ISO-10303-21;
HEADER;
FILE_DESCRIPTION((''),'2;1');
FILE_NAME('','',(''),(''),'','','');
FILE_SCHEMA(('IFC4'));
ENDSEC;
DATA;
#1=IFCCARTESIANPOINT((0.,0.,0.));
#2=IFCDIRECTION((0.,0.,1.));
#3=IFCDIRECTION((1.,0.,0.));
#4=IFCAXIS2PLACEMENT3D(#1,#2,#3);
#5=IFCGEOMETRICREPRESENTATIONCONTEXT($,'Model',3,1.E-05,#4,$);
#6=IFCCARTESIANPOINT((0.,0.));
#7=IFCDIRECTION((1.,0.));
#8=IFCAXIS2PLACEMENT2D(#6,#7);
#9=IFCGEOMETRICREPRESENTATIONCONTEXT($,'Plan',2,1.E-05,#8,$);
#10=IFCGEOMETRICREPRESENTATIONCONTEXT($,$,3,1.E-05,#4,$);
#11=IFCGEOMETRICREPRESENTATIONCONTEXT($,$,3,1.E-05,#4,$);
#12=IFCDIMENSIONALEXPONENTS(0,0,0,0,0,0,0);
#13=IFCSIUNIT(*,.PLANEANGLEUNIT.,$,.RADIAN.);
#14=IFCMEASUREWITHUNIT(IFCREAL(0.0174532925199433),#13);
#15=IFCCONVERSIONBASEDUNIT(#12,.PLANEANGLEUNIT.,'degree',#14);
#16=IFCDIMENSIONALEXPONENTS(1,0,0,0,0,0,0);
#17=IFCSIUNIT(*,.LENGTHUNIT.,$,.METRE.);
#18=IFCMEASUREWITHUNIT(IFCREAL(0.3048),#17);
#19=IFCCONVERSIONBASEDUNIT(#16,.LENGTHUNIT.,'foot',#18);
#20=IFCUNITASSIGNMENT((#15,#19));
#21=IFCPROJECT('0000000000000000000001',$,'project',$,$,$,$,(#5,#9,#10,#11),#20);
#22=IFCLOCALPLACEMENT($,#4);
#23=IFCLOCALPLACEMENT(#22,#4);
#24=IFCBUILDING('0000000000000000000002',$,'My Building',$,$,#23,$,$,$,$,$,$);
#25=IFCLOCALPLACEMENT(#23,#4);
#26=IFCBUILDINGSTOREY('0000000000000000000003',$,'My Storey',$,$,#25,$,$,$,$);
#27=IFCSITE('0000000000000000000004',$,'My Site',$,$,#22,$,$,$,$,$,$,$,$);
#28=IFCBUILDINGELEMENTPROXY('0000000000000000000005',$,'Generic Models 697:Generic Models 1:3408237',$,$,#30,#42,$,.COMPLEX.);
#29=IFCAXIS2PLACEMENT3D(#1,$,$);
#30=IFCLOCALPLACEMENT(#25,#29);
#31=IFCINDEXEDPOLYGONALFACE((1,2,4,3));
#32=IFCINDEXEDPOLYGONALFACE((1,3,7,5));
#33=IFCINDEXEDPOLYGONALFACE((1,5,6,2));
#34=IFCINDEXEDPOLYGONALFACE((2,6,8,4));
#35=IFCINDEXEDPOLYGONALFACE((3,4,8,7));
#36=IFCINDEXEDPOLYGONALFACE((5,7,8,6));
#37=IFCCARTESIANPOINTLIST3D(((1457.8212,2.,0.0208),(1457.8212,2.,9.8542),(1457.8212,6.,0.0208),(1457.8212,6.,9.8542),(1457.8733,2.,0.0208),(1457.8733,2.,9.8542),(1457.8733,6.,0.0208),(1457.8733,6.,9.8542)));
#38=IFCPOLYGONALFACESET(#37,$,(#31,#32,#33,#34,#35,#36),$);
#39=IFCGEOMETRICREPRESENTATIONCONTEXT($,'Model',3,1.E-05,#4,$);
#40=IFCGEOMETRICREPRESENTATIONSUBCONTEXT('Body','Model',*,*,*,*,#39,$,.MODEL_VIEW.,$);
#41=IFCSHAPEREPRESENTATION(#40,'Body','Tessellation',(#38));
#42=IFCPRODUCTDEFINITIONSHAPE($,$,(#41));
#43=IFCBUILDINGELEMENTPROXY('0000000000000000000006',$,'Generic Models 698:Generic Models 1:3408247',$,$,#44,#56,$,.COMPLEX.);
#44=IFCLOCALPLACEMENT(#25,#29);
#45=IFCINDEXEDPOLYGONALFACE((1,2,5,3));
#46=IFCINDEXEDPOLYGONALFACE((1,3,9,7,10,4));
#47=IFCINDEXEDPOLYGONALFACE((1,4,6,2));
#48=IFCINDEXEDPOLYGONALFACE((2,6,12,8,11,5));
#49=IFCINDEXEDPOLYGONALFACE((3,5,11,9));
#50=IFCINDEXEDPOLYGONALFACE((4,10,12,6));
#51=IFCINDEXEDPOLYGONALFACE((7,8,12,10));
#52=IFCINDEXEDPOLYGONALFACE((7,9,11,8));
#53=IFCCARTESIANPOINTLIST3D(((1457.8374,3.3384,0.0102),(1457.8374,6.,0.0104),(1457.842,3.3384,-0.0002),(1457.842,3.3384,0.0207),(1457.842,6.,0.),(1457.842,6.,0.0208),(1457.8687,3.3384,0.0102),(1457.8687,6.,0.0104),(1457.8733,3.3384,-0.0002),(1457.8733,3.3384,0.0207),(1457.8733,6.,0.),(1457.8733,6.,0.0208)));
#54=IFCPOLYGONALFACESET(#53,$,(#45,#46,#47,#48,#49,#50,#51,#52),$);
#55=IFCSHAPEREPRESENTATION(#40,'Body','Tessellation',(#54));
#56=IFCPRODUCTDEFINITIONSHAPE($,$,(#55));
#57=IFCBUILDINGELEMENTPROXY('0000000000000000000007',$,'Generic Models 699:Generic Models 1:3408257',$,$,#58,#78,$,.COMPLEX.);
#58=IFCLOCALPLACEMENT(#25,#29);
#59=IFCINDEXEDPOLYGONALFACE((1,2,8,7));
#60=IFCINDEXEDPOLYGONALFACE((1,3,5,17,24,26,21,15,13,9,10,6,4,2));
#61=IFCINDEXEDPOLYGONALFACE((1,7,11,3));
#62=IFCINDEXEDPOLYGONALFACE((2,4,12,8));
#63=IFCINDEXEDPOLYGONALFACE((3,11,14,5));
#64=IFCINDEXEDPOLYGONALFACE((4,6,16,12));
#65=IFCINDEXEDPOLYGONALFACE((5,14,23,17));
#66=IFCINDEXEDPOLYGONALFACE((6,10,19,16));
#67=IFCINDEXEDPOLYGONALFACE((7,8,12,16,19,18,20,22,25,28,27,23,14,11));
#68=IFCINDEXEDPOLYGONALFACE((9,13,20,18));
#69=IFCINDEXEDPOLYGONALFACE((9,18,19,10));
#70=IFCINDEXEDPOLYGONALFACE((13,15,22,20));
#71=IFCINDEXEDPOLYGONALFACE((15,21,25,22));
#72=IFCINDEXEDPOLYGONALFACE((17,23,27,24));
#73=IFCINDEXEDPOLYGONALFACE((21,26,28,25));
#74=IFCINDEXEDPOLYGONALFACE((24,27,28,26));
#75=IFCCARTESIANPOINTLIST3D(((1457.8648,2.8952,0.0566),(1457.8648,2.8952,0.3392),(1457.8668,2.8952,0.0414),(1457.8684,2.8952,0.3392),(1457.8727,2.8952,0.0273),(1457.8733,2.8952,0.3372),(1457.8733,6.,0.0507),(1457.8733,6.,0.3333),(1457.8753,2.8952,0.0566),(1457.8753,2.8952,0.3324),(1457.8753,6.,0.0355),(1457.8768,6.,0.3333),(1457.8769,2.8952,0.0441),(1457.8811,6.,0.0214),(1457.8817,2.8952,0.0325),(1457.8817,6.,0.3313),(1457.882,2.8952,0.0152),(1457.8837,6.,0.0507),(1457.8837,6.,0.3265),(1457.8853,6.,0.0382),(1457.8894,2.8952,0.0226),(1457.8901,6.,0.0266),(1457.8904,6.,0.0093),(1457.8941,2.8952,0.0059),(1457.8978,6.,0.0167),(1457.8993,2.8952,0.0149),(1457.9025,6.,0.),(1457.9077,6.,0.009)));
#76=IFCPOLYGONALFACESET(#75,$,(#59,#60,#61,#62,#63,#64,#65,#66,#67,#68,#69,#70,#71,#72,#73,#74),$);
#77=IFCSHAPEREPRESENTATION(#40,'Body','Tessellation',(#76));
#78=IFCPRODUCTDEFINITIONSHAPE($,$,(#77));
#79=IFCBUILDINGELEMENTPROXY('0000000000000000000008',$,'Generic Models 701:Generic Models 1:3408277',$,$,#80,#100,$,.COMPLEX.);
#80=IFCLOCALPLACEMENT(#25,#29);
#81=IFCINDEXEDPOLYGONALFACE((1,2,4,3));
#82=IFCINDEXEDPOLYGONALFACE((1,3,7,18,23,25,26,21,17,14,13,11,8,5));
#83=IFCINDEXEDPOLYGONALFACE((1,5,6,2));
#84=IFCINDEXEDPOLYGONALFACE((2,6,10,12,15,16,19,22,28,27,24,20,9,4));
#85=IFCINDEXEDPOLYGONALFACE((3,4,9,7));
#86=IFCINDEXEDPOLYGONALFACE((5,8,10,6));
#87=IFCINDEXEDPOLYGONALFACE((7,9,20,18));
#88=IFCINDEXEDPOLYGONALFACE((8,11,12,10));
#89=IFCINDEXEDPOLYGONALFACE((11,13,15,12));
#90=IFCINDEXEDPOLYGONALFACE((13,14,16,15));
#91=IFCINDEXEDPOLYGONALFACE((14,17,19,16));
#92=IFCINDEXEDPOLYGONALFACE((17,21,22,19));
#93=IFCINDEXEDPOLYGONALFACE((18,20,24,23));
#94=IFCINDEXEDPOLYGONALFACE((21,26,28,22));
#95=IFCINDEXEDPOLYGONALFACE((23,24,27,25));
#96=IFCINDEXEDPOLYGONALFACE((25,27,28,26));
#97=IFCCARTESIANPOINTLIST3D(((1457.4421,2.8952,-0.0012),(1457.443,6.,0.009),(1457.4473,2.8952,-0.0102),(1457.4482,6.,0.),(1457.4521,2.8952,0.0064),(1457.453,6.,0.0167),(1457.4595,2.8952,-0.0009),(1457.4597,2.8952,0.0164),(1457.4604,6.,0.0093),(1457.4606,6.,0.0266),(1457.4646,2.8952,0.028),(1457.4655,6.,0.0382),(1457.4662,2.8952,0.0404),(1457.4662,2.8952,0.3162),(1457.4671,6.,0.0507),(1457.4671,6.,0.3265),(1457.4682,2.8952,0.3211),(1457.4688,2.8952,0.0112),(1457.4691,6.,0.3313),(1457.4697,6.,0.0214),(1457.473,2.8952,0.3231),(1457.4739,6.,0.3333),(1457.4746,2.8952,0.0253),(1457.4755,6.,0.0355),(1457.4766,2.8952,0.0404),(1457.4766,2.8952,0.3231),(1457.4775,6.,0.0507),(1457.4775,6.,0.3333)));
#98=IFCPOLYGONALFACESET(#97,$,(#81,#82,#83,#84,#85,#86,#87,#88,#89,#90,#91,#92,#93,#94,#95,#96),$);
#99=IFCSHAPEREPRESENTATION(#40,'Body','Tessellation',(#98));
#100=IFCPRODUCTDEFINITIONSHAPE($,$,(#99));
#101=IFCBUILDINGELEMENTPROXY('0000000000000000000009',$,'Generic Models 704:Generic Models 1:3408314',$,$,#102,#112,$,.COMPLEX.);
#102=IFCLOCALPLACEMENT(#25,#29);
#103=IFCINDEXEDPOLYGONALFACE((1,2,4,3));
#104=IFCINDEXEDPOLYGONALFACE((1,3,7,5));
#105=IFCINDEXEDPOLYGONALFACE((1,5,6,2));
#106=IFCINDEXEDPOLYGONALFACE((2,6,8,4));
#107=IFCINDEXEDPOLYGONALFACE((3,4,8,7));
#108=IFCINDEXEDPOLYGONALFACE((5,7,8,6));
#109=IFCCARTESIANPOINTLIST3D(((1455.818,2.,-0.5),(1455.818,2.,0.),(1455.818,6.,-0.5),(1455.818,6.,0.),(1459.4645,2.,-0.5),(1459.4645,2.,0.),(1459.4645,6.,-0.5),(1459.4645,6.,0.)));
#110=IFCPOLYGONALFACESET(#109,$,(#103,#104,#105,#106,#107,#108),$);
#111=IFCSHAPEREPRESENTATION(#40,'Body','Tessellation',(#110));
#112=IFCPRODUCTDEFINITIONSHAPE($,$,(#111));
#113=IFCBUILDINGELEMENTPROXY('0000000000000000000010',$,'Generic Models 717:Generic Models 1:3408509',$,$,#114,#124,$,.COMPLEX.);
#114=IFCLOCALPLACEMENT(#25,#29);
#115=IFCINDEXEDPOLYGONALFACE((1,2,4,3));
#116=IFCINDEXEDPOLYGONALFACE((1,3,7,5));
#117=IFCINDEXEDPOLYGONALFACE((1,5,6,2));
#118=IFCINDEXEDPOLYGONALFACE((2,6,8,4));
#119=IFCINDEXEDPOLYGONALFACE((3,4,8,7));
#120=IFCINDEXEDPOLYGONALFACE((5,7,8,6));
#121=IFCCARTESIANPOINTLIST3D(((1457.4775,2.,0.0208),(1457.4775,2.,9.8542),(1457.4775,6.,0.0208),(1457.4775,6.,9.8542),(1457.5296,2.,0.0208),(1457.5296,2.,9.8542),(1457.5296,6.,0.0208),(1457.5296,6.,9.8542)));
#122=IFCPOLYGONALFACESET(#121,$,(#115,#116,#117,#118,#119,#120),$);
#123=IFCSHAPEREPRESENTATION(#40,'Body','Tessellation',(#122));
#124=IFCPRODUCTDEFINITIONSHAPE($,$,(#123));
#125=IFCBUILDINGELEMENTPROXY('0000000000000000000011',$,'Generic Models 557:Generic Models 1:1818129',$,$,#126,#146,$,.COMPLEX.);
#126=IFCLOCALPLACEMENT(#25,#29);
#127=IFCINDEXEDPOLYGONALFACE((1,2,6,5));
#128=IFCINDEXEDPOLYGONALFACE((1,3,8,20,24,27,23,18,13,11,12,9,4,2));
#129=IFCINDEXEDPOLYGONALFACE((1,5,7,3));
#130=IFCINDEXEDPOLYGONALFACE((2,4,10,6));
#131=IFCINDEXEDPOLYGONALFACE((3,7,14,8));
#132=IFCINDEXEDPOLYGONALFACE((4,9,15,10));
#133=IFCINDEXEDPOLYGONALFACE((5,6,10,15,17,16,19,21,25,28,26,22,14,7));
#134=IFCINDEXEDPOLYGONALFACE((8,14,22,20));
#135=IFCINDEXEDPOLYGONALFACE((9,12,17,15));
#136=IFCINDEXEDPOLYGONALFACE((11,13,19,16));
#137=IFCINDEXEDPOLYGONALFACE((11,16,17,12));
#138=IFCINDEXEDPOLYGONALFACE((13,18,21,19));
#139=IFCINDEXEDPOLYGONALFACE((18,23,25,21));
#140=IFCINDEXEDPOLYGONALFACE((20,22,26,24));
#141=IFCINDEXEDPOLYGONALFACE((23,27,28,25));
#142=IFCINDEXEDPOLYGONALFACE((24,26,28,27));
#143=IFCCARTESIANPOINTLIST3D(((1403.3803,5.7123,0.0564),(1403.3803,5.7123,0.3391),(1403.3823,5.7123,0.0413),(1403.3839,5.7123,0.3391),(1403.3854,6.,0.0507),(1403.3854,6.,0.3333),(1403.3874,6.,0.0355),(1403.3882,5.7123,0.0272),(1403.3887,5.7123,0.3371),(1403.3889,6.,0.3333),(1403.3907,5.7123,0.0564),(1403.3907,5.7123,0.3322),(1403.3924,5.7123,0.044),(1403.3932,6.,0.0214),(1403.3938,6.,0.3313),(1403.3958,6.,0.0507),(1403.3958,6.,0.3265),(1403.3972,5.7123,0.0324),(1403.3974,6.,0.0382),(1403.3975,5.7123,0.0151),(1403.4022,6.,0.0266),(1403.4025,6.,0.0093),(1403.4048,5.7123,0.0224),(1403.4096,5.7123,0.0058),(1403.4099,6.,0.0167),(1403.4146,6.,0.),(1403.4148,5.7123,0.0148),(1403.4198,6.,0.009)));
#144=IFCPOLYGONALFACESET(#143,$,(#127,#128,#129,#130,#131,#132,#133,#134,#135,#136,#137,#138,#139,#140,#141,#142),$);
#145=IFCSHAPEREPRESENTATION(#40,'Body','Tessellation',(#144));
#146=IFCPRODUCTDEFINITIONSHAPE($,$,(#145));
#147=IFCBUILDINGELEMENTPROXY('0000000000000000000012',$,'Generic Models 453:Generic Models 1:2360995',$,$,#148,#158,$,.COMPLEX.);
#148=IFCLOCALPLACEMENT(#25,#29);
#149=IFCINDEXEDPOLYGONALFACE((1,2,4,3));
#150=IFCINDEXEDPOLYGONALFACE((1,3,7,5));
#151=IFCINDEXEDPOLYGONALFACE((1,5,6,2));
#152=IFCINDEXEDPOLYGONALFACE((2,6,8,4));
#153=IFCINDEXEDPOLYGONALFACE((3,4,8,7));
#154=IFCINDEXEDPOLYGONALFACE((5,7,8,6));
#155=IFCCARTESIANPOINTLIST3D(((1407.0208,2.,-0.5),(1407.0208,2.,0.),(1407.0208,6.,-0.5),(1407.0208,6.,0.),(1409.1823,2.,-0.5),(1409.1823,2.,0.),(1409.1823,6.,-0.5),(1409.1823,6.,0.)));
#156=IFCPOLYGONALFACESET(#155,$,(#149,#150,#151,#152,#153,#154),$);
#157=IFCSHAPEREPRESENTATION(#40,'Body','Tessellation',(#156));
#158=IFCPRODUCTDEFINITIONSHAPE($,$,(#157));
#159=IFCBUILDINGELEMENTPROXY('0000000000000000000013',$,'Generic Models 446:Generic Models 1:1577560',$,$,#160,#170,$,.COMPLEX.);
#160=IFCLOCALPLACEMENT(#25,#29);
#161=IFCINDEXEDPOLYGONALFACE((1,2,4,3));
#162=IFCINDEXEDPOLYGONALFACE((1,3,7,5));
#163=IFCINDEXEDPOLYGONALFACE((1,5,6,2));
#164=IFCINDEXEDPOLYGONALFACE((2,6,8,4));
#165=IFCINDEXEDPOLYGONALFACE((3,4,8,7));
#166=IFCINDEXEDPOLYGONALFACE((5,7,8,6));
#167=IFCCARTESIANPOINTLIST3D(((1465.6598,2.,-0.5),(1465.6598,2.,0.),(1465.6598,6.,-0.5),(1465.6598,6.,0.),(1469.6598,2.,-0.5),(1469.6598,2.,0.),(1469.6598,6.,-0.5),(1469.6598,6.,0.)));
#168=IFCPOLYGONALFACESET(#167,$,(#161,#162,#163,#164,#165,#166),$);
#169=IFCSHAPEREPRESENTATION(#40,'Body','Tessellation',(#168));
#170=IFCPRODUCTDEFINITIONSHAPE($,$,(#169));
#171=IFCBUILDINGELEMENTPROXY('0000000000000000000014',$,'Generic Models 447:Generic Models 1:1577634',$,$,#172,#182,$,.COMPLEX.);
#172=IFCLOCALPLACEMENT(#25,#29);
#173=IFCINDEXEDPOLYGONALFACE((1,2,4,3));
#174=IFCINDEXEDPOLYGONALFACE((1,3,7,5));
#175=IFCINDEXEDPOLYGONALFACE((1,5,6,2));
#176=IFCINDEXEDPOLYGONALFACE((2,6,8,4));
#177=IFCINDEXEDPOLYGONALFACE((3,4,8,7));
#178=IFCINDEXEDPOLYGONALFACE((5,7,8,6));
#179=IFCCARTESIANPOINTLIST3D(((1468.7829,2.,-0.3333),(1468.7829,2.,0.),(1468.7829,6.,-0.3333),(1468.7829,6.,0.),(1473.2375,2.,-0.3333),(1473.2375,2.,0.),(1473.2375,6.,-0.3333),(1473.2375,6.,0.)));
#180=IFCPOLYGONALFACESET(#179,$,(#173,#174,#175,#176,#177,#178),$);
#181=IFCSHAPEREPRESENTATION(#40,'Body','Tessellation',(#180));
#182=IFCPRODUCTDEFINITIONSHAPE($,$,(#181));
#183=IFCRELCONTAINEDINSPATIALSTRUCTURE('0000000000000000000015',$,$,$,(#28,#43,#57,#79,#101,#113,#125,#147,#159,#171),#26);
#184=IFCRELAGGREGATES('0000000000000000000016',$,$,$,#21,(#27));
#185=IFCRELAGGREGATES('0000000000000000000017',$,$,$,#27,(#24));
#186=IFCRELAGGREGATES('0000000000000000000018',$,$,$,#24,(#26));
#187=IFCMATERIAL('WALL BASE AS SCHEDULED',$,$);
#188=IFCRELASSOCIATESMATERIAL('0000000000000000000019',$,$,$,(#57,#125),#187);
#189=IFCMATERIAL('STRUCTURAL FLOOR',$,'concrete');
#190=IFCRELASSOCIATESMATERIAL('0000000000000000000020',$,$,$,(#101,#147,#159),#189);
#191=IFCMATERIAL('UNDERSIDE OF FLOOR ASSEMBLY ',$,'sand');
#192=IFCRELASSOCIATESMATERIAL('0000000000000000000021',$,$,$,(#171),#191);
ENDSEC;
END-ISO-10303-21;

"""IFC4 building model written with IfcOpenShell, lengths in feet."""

from ifc_helpers import new_model, entity, si_unit, converted_unit, frame, origin_with_axes, origin_2d_with_axis, place, context, subcontext, project, spatial, polyline, line, indexed_curve, outline, extrude, material, element, save


model = new_model("IFC4")

# Units and contexts
model_context_1 = context("Model", 3, precision=1e-05, world=origin_with_axes())
plan_context = context("Plan", 2, precision=1e-05, world=origin_2d_with_axis())
model_context_2 = context("Model", 3, precision=1e-05, world=origin_with_axes())
context_of_model_1 = context(None, 3, precision=1e-05, world=origin_with_axes())
context_of_model_2 = context(None, 3, precision=1e-05, world=origin_with_axes())
body_context = subcontext(model_context_2, "Body", "Model", "MODEL_VIEW")
ifc_project = project(units=[converted_unit("PLANEANGLEUNIT", "degree", entity("IfcReal", 0.0174532925199433), si_unit("PLANEANGLEUNIT", "RADIAN"), dimensions=[0, 0, 0, 0, 0, 0, 0]), converted_unit("LENGTHUNIT", "foot", entity("IfcReal", 0.3048), si_unit("LENGTHUNIT", "METRE"), dimensions=[1, 0, 0, 0, 0, 0, 0])], contexts=[model_context_1, plan_context, context_of_model_1, context_of_model_2])

# Site, building, storey
site_placement = place(None, origin_with_axes())
site = spatial("IfcSite", under=ifc_project, at=site_placement, Name="My Site")
building_placement = place(site_placement, origin_with_axes())
building = spatial("IfcBuilding", under=site, at=building_placement, Name="My Building")
storey_placement = place(building_placement, origin_with_axes())
storey = spatial("IfcBuildingStorey", under=building, at=storey_placement, Name="My Storey")

# Building element proxies
ifc_material_1 = material(Name="WALL BASE AS SCHEDULED")
ifc_material_2 = material(Name="STRUCTURAL FLOOR", Category="concrete")
proxy_1_placement = place(storey_placement, frame((1457.8212, 6.0, 0.0208), z_axis=(0.0, -1.0, 0.0), x_axis=(0.0, 0.0, 1.0)))
element("IfcBuildingElementProxy", 1, at=proxy_1_placement, inside=storey, Name="Generic Models 697:Generic Models 1:3408237", PredefinedType="COMPLEX", context=body_context, shape_type="SweptSolid", body=[
    extrude(outline(polyline([(-4.9167, -0.026), (4.9167, -0.026), (4.9167, 0.026), (-4.9167, 0.026), (-4.9167, -0.026)])), frame((4.9167, -0.026, 0.0), z_axis=(0.0, 0.0, -1.0), x_axis=(1.0, 0.0, 0.0)), (0.0, 0.0, -1.0), 4.0),
])
proxy_2_placement = place(storey_placement, frame((1457.8375, 6.0, 0.0), z_axis=(0.0, -1.0, 0.0), x_axis=(0.0, 0.0, 1.0)))
element("IfcBuildingElementProxy", 2, at=proxy_2_placement, inside=storey, Name="Generic Models 698:Generic Models 1:3408247", PredefinedType="COMPLEX", context=body_context, shape_type="SweptSolid", body=[
    extrude(outline(polyline([(0.0201, 0.0), (0.0107, 0.0065), (0.0093, 0.0178), (-0.0175, 0.0016), (-0.016, -0.0097), (-0.0066, -0.0162), (0.0201, 0.0)])), frame((0.0104, -0.0186, 0.0), z_axis=(0.0, 0.0, -1.0), x_axis=(0.51911, -0.854707, 0.0)), (-0.000034, 0.000057, -1.0), 2.6616),
])
proxy_3_placement = place(storey_placement, frame((1457.8733, 6.0, 0.0), z_axis=(0.0, -1.0, 0.0), x_axis=(0.0, 0.0, 1.0)))
element("IfcBuildingElementProxy", 3, at=proxy_3_placement, inside=storey, material=ifc_material_1, Name="Generic Models 699:Generic Models 1:3408257", PredefinedType="COMPLEX", context=body_context, shape_type="SweptSolid", body=[
    extrude(outline(polyline([(0.2206, 0.0), (0.2204, 0.0036), (0.2182, 0.0083), (0.2132, 0.01), (-0.0621, -0.0058), (-0.0747, -0.0049), (-0.0865, -0.0007), (-0.0969, 0.0063), (-0.1051, 0.0158), (-0.1138, 0.0101), (-0.1038, -0.0014), (-0.0912, -0.01), (-0.0768, -0.0151), (-0.0615, -0.0162), (0.2206, 0.0)])), frame((0.113, -0.0126, 0.0), z_axis=(0.0, 0.0, -1.0), x_axis=(0.998358, 0.057286, 0.0)), (0.002054, -0.002598, -0.999995), 3.1048),
])
proxy_4_placement = place(storey_placement, frame((1457.443, 6.0, 0.0), z_axis=(0.0, -1.0, 0.0), x_axis=(0.0, 0.0, 1.0)))
element("IfcBuildingElementProxy", 4, at=proxy_4_placement, inside=storey, Name="Generic Models 701:Generic Models 1:3408277", PredefinedType="COMPLEX", context=body_context, shape_type="SweptSolid", body=[
    extrude(outline(polyline([(-0.0624, 0.0022), (0.2134, 0.0022), (0.2183, 0.0042), (0.2203, 0.0091), (0.2203, 0.0126), (-0.0624, 0.0126), (-0.0775, 0.0106), (-0.0916, 0.0048), (-0.1037, -0.0045), (-0.113, -0.0166), (-0.104, -0.0218), (-0.0964, -0.0119), (-0.0864, -0.0042), (-0.0748, 0.0006), (-0.0624, 0.0022)])), frame((0.113, -0.0218, 0.0), z_axis=(0.0, 0.0, -1.0), x_axis=(1.0, 0.0, 0.0)), (-0.003299, -0.000291, -0.999995), 3.1048),
])
proxy_5_placement = place(storey_placement, frame((1455.818, 6.0, -0.5), z_axis=(0.0, -1.0, 0.0), x_axis=(0.0, 0.0, 1.0)))
element("IfcBuildingElementProxy", 5, at=proxy_5_placement, inside=storey, material=ifc_material_2, Name="Generic Models 704:Generic Models 1:3408314", PredefinedType="COMPLEX", context=body_context, shape_type="SweptSolid", body=[
    extrude(outline(polyline([(-0.25, -1.8232), (0.25, -1.8232), (0.25, 1.8232), (-0.25, 1.8232), (-0.25, -1.8232)])), frame((0.25, -1.8232, 0.0), z_axis=(0.0, 0.0, -1.0), x_axis=(1.0, 0.0, 0.0)), (0.0, 0.0, -1.0), 4.0),
])
proxy_6_placement = place(storey_placement, frame((1457.4775, 6.0, 0.0208), z_axis=(0.0, -1.0, 0.0), x_axis=(0.0, 0.0, 1.0)))
element("IfcBuildingElementProxy", 6, at=proxy_6_placement, inside=storey, Name="Generic Models 717:Generic Models 1:3408509", PredefinedType="COMPLEX", context=body_context, shape_type="SweptSolid", body=[
    extrude(outline(polyline([(-0.026, -4.9167), (0.026, -4.9167), (0.026, 4.9167), (-0.026, 4.9167), (-0.026, -4.9167)])), frame((4.9167, -0.026, 0.0), z_axis=(0.0, 0.0, -1.0), x_axis=(0.0, -1.0, 0.0)), (0.0, 0.0, -1.0), 4.0),
])
proxy_7_placement = place(storey_placement, frame((1403.3854, 6.0, 0.0), z_axis=(0.0, -1.0, 0.0), x_axis=(0.0, 0.0, 1.0)))
element("IfcBuildingElementProxy", 7, at=proxy_7_placement, inside=storey, material=ifc_material_1, Name="Generic Models 557:Generic Models 1:1818129", PredefinedType="COMPLEX", context=body_context, shape_type="SweptSolid", body=[
    extrude(outline(polyline([(0.1038, 0.0), (0.0913, 0.0088), (0.077, 0.014), (0.0618, 0.0153), (-0.2206, 0.0031), (-0.2205, -0.0005), (-0.2183, -0.0052), (-0.2133, -0.007), (0.0622, 0.0049), (0.0747, 0.0038), (0.0865, -0.0005), (0.0968, -0.0077), (0.1049, -0.0173), (0.1137, -0.0117), (0.1038, 0.0)])), frame((0.113, -0.0126, 0.0), z_axis=(0.0, 0.0, -1.0), x_axis=(-0.999059, -0.043362, 0.0)), (-0.020742, 0.016656, -0.999646), 0.2878),
])
proxy_8_placement = place(storey_placement, frame((1407.0208, 6.0, -0.5), z_axis=(0.0, -1.0, 0.0), x_axis=(0.0, 0.0, 1.0)))
element("IfcBuildingElementProxy", 8, at=proxy_8_placement, inside=storey, material=ifc_material_2, Name="Generic Models 453:Generic Models 1:2360995", PredefinedType="COMPLEX", context=body_context, shape_type="SweptSolid", body=[
    extrude(outline(polyline([(-0.25, -1.0807), (0.25, -1.0807), (0.25, 1.0807), (-0.25, 1.0807), (-0.25, -1.0807)])), frame((0.25, -1.0807, 0.0), z_axis=(0.0, 0.0, -1.0), x_axis=(1.0, 0.0, 0.0)), (0.0, 0.0, -1.0), 4.0),
])
proxy_9_placement = place(storey_placement, frame((1465.6598, 6.0, -0.5), z_axis=(0.0, -1.0, 0.0), x_axis=(0.0, 0.0, 1.0)))
element("IfcBuildingElementProxy", 9, at=proxy_9_placement, inside=storey, material=ifc_material_2, Name="Generic Models 446:Generic Models 1:1577560", PredefinedType="COMPLEX", context=body_context, shape_type="SweptSolid", body=[
    extrude(outline(polyline([(-2.0, -0.25), (2.0, -0.25), (2.0, 0.25), (-2.0, 0.25), (-2.0, -0.25)])), frame((0.25, -2.0, 0.0), z_axis=(0.0, 0.0, -1.0), x_axis=(0.0, 1.0, 0.0)), (0.0, 0.0, -1.0), 4.0),
])
ifc_material_3 = material(Name="UNDERSIDE OF FLOOR ASSEMBLY ", Category="sand")
proxy_10_placement = place(storey_placement, frame((1468.7829, 6.0, -0.3333), z_axis=(0.0, -1.0, 0.0), x_axis=(0.0, 0.0, 1.0)))
element("IfcBuildingElementProxy", 10, at=proxy_10_placement, inside=storey, material=ifc_material_3, Name="Generic Models 447:Generic Models 1:1577634", PredefinedType="COMPLEX", context=body_context, shape_type="SweptSolid", body=[
    extrude(outline(indexed_curve([(-2.4546, -0.1667), (2.0, -0.1667), (2.0, 0.1667), (-2.4546, 0.1667)], segments=[line(3, 2), line(2, 1), line(1, 4), line(4, 3)], self_intersect=False)), frame((0.1667, -2.0, 0.0), z_axis=(0.0, 0.0, -1.0), x_axis=(0.0, 1.0, 0.0)), (0.0, 0.0, -1.0), 4.0),
])

save(model, "model.ifc")
